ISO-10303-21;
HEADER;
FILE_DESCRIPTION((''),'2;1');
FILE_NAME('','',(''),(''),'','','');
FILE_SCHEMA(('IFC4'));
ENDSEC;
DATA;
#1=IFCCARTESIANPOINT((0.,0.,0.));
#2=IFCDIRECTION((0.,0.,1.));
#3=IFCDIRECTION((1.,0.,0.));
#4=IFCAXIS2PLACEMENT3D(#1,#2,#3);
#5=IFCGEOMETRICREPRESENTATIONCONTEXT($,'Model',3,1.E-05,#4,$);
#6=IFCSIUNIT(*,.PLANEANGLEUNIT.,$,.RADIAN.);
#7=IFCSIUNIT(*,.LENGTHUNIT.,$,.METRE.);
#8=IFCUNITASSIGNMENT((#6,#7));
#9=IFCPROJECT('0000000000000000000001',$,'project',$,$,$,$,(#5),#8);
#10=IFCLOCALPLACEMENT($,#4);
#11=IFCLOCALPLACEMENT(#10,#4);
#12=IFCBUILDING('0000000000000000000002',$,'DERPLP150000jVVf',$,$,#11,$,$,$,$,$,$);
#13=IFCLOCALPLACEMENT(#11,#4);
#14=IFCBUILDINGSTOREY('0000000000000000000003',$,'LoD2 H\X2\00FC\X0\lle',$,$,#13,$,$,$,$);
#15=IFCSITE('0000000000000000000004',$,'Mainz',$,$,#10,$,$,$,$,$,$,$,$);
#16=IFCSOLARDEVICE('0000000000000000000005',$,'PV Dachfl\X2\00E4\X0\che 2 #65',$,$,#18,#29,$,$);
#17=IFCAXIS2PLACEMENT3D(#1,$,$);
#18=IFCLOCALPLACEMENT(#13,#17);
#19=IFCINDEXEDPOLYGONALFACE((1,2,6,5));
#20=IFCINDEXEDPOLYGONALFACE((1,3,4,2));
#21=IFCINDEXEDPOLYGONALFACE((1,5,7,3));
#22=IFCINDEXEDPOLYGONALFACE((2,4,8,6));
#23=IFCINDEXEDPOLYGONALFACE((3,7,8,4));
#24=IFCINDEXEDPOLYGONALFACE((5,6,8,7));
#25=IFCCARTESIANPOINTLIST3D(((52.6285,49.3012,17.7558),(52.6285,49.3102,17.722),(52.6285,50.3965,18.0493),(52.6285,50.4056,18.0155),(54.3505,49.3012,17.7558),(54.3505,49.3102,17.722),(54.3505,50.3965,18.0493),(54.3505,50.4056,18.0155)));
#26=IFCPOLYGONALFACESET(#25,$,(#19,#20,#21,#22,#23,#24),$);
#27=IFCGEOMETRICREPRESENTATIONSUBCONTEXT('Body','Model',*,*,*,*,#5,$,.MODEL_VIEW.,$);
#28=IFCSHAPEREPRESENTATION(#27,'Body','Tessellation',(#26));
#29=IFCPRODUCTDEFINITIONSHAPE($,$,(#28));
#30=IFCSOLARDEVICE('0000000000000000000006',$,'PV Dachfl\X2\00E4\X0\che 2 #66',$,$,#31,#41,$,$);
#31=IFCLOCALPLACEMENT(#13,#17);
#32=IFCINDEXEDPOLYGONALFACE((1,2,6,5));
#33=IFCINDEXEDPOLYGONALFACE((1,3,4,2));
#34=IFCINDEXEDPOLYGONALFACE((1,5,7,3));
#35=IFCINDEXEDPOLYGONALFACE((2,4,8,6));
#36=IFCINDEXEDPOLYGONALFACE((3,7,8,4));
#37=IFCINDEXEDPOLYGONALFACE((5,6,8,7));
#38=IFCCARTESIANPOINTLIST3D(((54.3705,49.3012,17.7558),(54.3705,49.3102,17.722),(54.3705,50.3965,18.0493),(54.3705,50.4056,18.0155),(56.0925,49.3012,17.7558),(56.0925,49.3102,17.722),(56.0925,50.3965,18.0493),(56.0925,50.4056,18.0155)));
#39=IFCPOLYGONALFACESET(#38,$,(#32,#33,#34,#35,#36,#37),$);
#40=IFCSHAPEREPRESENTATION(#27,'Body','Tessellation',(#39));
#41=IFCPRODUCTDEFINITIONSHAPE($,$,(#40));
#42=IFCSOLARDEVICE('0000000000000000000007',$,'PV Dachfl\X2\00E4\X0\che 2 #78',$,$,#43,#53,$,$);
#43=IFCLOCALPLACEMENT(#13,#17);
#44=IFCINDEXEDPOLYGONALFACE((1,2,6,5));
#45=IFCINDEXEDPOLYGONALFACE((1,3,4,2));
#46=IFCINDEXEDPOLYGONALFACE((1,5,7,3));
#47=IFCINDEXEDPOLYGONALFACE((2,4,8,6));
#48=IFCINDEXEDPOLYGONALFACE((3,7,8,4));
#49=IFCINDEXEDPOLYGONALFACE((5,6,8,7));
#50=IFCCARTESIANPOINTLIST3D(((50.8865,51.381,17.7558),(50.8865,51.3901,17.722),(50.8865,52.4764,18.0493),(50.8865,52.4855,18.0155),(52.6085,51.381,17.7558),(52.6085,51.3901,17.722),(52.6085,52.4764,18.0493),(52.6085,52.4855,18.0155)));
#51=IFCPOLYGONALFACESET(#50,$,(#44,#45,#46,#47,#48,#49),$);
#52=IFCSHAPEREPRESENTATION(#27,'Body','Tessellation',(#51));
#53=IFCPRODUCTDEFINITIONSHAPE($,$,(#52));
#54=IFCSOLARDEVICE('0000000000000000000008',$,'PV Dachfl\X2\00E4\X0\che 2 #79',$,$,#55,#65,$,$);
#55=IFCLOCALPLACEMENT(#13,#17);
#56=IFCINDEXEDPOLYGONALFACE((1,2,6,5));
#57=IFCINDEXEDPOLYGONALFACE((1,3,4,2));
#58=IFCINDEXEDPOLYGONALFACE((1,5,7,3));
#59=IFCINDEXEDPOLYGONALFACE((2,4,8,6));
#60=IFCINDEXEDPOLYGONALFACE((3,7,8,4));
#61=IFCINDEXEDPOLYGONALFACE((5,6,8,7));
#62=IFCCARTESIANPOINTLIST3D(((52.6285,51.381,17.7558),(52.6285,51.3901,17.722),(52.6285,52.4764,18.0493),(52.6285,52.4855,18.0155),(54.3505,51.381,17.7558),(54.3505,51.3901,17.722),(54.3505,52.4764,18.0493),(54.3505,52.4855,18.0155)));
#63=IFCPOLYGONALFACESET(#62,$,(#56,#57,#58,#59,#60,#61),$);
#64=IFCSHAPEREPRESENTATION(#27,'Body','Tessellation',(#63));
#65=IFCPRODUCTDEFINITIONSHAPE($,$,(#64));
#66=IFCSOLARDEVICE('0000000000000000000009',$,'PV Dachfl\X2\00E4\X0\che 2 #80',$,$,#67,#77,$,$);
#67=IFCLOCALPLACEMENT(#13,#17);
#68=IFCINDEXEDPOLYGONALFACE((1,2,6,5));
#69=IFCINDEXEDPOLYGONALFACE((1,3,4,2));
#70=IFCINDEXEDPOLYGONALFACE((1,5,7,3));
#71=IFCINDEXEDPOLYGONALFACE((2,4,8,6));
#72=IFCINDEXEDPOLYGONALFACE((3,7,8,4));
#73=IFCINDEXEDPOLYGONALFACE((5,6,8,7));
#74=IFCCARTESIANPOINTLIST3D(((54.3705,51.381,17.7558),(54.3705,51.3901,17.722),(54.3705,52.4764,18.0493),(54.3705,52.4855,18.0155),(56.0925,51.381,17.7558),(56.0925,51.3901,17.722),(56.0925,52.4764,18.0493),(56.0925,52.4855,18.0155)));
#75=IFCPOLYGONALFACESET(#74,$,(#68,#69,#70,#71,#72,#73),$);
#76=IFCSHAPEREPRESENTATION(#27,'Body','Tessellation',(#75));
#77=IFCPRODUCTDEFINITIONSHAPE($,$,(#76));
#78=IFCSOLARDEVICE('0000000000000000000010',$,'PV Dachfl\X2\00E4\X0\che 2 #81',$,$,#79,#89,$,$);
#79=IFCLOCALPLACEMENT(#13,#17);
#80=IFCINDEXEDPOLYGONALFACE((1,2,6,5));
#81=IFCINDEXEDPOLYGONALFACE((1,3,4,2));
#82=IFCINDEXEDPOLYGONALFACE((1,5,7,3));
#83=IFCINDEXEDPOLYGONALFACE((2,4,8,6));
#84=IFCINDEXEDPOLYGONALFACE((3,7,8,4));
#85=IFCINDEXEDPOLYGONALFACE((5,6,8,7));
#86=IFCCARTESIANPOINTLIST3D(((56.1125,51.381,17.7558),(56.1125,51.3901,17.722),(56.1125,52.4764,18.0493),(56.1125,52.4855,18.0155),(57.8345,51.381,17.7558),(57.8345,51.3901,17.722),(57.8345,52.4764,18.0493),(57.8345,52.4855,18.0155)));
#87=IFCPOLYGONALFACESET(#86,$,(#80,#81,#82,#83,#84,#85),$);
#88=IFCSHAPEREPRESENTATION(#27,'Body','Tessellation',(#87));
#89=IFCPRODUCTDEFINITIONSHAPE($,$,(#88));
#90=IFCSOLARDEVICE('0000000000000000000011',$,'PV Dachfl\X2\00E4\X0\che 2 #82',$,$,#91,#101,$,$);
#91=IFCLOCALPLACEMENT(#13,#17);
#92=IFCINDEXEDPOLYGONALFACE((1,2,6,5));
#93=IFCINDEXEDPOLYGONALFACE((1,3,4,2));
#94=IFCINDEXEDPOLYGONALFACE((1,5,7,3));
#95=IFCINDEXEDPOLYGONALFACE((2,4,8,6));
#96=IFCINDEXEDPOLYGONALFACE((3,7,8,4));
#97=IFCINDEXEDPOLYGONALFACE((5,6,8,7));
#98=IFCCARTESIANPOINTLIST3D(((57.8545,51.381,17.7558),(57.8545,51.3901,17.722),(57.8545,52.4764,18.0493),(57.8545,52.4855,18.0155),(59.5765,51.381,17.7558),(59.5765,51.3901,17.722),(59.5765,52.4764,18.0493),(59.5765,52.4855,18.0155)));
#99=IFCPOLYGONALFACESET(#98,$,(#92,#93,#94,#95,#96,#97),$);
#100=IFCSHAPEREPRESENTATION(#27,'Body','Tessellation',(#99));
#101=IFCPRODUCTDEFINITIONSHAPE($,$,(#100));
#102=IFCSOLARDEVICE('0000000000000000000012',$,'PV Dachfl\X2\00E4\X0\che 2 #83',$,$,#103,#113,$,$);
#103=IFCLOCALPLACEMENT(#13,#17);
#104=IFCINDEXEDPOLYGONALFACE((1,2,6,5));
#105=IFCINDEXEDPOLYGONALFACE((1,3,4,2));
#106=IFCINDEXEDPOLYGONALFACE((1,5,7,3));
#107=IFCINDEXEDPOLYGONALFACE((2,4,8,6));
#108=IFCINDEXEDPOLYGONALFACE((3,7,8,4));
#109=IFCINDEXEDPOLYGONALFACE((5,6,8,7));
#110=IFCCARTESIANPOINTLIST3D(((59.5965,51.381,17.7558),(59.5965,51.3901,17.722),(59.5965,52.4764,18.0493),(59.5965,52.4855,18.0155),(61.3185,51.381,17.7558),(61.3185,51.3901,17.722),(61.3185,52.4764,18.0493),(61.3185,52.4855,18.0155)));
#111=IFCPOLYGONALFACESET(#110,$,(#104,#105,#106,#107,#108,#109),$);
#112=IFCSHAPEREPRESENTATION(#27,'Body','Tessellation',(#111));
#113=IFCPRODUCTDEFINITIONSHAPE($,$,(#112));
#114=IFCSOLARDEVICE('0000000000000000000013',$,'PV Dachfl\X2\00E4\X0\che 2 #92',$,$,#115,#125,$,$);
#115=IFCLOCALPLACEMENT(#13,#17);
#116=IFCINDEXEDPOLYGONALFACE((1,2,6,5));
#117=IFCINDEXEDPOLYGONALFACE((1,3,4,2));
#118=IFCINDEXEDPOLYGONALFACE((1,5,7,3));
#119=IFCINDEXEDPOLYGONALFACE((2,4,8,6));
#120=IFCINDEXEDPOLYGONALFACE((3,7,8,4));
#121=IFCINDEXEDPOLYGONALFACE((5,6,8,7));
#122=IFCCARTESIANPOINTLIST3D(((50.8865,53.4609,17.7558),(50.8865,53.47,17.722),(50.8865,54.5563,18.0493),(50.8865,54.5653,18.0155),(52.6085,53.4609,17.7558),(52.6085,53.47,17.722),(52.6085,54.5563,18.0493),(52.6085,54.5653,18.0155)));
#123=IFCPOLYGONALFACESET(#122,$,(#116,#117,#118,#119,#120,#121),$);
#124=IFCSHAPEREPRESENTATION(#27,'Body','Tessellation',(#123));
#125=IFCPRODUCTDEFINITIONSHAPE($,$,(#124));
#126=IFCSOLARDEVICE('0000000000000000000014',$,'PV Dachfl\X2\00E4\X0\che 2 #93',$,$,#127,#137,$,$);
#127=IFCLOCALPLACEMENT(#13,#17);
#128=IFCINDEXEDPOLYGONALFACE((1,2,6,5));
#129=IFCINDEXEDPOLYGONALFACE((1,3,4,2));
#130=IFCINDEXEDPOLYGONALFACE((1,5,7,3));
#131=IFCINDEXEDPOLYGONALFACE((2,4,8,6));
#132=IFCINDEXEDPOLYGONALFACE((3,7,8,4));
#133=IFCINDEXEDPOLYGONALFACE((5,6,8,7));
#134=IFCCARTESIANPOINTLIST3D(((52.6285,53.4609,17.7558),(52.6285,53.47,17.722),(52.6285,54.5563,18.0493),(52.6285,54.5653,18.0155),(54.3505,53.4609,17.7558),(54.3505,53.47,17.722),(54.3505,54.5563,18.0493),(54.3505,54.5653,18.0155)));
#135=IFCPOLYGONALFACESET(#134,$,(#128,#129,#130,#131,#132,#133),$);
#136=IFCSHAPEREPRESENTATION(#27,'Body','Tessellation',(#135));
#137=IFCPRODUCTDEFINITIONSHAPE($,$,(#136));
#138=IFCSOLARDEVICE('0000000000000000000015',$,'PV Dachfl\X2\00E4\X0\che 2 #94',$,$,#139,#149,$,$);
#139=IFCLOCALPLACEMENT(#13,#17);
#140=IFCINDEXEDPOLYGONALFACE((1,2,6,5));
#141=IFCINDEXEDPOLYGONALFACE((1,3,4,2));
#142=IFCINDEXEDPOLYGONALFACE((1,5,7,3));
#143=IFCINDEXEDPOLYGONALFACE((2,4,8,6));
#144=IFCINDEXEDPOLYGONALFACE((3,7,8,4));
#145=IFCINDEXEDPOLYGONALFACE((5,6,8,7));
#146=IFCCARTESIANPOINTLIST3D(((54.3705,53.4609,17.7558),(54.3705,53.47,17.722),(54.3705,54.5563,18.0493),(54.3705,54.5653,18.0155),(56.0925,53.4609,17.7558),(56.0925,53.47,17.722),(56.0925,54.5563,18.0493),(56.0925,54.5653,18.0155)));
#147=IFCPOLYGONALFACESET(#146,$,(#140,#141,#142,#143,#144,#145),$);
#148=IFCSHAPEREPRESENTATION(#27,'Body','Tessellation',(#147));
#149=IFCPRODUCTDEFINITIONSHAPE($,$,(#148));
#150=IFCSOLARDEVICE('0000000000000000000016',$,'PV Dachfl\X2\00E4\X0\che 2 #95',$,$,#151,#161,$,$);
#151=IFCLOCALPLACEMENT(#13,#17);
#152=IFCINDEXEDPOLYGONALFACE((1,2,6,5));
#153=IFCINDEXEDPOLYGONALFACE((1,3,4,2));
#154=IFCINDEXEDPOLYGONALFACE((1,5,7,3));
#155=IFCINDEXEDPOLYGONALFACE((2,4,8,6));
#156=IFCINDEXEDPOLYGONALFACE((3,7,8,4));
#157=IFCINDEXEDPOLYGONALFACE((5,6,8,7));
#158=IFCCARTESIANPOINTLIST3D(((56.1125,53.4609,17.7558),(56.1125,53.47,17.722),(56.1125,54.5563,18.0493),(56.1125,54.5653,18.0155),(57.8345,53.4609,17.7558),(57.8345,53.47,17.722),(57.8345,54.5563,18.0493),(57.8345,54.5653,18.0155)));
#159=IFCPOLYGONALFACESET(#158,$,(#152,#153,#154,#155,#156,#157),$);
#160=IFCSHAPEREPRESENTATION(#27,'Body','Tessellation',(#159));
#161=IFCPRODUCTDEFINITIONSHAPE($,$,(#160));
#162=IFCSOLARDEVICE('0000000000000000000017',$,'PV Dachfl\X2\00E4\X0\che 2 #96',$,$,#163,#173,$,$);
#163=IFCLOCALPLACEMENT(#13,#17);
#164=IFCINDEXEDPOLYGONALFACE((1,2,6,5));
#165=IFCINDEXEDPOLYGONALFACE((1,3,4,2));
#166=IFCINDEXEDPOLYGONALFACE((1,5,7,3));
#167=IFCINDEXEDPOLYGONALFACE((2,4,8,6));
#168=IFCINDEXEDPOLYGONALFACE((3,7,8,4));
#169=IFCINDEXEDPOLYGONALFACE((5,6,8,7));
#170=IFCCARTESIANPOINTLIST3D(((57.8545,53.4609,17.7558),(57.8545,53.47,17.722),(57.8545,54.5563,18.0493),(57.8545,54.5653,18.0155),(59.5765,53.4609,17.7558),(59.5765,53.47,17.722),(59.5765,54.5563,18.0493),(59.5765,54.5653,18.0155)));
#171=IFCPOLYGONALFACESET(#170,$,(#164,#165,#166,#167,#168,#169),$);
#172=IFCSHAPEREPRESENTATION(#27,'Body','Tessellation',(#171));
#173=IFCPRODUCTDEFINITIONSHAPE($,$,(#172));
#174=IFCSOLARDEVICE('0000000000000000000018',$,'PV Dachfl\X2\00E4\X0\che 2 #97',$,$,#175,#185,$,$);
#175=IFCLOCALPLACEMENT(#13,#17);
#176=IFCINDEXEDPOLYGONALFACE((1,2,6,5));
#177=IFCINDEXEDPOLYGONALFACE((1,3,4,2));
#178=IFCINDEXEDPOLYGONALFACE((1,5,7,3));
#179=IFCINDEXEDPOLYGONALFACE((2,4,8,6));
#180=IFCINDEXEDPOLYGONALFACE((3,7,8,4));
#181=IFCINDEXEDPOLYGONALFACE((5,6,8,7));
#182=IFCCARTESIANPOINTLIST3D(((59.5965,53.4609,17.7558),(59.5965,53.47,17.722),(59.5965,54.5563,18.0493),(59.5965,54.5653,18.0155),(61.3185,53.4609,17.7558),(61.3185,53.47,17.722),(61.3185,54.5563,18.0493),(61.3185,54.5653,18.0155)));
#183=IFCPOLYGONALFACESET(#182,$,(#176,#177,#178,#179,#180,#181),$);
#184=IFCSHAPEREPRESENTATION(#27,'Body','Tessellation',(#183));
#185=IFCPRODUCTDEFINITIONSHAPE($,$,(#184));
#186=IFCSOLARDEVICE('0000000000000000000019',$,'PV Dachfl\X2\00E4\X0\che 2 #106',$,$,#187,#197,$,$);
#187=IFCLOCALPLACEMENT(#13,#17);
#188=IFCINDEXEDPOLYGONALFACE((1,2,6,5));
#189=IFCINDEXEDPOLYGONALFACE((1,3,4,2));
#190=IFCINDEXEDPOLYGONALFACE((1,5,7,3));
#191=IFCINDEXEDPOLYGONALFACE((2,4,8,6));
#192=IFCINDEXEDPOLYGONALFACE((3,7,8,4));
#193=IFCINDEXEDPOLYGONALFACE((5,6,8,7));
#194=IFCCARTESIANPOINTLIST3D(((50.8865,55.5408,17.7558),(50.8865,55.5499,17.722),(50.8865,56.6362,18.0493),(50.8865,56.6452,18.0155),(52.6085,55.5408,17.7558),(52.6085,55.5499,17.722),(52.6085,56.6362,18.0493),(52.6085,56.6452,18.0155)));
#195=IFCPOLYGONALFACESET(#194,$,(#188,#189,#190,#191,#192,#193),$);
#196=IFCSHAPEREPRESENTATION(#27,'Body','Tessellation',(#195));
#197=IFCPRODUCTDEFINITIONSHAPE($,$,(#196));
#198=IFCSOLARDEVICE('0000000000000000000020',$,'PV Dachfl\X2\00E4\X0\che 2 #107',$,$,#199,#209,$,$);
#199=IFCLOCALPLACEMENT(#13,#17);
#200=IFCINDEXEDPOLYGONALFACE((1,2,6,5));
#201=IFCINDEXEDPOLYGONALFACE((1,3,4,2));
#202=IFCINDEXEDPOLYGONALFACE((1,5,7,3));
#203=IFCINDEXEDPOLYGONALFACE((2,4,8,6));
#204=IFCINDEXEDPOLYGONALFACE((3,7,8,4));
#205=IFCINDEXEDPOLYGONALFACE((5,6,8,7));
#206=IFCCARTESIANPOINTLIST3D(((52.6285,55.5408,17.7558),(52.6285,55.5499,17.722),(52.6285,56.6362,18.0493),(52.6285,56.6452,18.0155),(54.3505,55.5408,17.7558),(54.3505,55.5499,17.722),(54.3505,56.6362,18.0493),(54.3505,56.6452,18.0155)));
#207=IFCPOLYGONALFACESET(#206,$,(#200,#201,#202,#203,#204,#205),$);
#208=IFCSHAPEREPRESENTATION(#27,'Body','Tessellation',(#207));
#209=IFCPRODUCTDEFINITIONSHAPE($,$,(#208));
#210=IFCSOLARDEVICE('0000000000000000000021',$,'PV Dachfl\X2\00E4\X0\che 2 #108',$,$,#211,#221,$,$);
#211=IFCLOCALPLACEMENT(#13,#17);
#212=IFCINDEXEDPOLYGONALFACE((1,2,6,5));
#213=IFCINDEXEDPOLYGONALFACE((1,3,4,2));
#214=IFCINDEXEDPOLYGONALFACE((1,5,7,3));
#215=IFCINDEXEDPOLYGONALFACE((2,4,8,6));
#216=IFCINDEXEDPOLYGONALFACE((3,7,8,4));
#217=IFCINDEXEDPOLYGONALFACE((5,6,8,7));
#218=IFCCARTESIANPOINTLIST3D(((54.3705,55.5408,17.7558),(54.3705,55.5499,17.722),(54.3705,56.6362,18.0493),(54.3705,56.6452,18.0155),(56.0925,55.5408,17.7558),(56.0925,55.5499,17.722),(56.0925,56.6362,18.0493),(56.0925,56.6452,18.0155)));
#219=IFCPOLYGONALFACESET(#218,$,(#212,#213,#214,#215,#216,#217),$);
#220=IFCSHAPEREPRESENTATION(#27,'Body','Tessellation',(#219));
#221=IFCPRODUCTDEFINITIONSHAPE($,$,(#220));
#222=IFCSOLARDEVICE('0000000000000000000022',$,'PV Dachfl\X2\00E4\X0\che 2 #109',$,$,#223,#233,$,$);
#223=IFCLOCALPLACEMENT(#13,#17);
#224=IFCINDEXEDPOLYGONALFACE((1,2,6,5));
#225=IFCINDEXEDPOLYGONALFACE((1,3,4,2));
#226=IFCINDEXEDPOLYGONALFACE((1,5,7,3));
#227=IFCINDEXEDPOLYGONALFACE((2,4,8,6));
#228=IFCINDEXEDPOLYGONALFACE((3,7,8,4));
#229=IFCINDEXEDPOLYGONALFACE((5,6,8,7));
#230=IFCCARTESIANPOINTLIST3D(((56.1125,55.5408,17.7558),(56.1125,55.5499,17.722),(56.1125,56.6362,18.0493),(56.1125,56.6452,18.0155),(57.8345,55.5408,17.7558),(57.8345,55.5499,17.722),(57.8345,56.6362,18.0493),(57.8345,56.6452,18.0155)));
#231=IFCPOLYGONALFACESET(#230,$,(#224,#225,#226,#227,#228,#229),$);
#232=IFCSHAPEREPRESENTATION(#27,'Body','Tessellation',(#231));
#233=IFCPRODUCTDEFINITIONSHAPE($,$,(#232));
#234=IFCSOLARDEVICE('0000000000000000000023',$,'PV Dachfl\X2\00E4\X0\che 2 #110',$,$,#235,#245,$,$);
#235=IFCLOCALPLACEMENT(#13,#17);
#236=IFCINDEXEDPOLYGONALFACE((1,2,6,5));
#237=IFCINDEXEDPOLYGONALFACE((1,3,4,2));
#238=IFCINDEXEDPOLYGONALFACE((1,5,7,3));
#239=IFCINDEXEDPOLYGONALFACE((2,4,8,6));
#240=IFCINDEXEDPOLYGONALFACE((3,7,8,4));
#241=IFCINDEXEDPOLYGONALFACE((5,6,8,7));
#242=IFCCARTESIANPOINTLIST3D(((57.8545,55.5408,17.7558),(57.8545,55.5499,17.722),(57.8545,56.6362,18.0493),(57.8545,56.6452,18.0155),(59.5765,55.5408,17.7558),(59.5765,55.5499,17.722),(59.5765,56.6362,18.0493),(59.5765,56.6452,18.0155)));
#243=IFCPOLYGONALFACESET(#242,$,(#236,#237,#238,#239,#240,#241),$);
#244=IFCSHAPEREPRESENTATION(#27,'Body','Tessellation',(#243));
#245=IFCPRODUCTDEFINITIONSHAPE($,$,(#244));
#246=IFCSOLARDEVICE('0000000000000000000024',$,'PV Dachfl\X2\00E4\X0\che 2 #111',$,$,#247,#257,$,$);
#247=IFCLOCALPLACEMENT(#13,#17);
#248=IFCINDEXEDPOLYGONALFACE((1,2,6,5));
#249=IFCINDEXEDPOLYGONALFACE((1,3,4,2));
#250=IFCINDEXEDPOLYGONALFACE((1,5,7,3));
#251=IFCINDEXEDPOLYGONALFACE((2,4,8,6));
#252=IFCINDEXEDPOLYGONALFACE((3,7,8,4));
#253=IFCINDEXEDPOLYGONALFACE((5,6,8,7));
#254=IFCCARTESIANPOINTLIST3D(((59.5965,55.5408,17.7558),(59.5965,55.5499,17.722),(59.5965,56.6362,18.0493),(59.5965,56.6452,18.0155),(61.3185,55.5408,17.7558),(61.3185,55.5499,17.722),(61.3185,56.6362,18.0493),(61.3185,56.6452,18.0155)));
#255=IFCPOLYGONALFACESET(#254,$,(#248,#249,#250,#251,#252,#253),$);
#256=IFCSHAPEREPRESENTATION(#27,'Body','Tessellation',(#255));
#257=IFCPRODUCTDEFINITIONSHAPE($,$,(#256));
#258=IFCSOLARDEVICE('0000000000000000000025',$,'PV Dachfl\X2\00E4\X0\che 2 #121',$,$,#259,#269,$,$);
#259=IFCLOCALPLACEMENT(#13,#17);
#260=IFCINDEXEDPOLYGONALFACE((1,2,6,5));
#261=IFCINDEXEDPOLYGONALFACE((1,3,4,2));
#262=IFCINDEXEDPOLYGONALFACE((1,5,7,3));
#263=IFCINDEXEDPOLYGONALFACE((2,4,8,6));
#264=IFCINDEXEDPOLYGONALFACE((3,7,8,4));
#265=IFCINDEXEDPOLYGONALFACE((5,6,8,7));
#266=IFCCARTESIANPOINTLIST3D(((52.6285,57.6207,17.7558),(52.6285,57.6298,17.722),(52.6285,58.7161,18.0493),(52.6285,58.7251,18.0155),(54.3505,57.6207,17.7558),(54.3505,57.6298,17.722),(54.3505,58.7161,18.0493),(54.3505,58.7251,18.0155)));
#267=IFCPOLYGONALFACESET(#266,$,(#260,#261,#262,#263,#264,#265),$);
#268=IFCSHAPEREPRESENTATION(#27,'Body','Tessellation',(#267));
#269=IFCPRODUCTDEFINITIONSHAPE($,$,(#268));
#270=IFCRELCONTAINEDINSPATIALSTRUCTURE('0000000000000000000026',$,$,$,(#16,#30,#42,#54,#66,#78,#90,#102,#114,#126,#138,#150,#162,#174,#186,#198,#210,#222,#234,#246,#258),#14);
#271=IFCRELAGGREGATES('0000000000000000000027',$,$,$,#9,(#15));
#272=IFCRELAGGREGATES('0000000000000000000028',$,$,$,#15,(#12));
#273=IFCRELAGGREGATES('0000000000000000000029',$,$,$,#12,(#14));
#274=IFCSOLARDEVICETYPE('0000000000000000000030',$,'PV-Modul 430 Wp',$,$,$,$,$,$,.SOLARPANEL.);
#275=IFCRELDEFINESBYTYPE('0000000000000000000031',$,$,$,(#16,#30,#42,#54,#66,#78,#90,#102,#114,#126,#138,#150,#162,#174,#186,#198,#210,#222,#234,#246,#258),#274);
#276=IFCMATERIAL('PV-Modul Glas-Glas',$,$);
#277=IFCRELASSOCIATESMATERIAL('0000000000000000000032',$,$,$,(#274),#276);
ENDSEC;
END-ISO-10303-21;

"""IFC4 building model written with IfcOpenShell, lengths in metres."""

from ifc_helpers import new_model, si_unit, frame, frame_2d, origin, origin_with_axes, place, context, subcontext, project, spatial, rectangle, extrude, source, transform, mapped, material, type_object, type_shapes, element, save


model = new_model("IFC4")

# Units and contexts
model_context = context("Model", 3, precision=1e-05, world=origin_with_axes())
body_context = subcontext(model_context, "Body", "Model", "MODEL_VIEW")
ifc_project = project(units=[si_unit("PLANEANGLEUNIT", "RADIAN"), si_unit("LENGTHUNIT", "METRE")], contexts=[model_context])

# Site, building, storey
site_placement = place(None, origin_with_axes())
site = spatial("IfcSite", under=ifc_project, at=site_placement, Name="Mainz")
building_placement = place(site_placement, origin_with_axes())
building = spatial("IfcBuilding", under=site, at=building_placement, Name="DERPLP150000jVVf")
storey_placement = place(building_placement, origin_with_axes())
storey = spatial("IfcBuildingStorey", under=building, at=storey_placement, Name="LoD2 Hülle")

# Solar devices
ifc_material = material(Name="PV-Modul Glas-Glas")
solar_device_type = type_object("IfcSolarDeviceType", Name="PV-Modul 430 Wp", PredefinedType="SOLARPANEL", material=ifc_material)
shared_shape = source(origin_with_axes(), body_context, "Body", "SweptSolid", [
    extrude(rectangle(XDim=1.722, YDim=1.134, at=frame_2d((0.861, 0.567))), origin(), (0.0, 0.0, 1.0), 0.035),
])
type_shapes(solar_device_type, [shared_shape])
for number, where, z_axis, x_axis, name in (
    (1, (52.6285, 49.3102, 17.722), (0.0, -0.258819, 0.965926), (1.0, 0.0, 0.0), "PV Dachfläche 2 #65"),
    (2, (54.3705, 49.3102, 17.722), (0.0, -0.258819, 0.965926), (1.0, 0.0, 0.0), "PV Dachfläche 2 #66"),
    (3, (50.8865, 51.3901, 17.722), (0.0, -0.258819, 0.965926), (1.0, 0.0, 0.0), "PV Dachfläche 2 #78"),
    (4, (52.6285, 51.3901, 17.722), (0.0, -0.258819, 0.965926), (1.0, 0.0, 0.0), "PV Dachfläche 2 #79"),
    (5, (54.3705, 51.3901, 17.722), (0.0, -0.258819, 0.965926), (1.0, 0.0, 0.0), "PV Dachfläche 2 #80"),
    (6, (56.1125, 51.3901, 17.722), (0.0, -0.258819, 0.965926), (1.0, 0.0, 0.0), "PV Dachfläche 2 #81"),
    (7, (57.8545, 51.3901, 17.722), (0.0, -0.258819, 0.965926), (1.0, 0.0, 0.0), "PV Dachfläche 2 #82"),
    (8, (59.5965, 51.3901, 17.722), (0.0, -0.258819, 0.965926), (1.0, 0.0, 0.0), "PV Dachfläche 2 #83"),
    (9, (50.8865, 53.47, 17.722), (0.0, -0.258819, 0.965926), (1.0, 0.0, 0.0), "PV Dachfläche 2 #92"),
    (10, (52.6285, 53.47, 17.722), (0.0, -0.258819, 0.965926), (1.0, 0.0, 0.0), "PV Dachfläche 2 #93"),
    (11, (54.3705, 53.47, 17.722), (0.0, -0.258819, 0.965926), (1.0, 0.0, 0.0), "PV Dachfläche 2 #94"),
    (12, (56.1125, 53.47, 17.722), (0.0, -0.258819, 0.965926), (1.0, 0.0, 0.0), "PV Dachfläche 2 #95"),
    (13, (57.8545, 53.47, 17.722), (0.0, -0.258819, 0.965926), (1.0, 0.0, 0.0), "PV Dachfläche 2 #96"),
    (14, (59.5965, 53.47, 17.722), (0.0, -0.258819, 0.965926), (1.0, 0.0, 0.0), "PV Dachfläche 2 #97"),
    (15, (50.8865, 55.5499, 17.722), (0.0, -0.258819, 0.965926), (1.0, 0.0, 0.0), "PV Dachfläche 2 #106"),
    (16, (52.6285, 55.5499, 17.722), (0.0, -0.258819, 0.965926), (1.0, 0.0, 0.0), "PV Dachfläche 2 #107"),
    (17, (54.3705, 55.5499, 17.722), (0.0, -0.258819, 0.965926), (1.0, 0.0, 0.0), "PV Dachfläche 2 #108"),
    (18, (56.1125, 55.5499, 17.722), (0.0, -0.258819, 0.965926), (1.0, 0.0, 0.0), "PV Dachfläche 2 #109"),
    (19, (57.8545, 55.5499, 17.722), (0.0, -0.258819, 0.965926), (1.0, 0.0, 0.0), "PV Dachfläche 2 #110"),
    (20, (59.5965, 55.5499, 17.722), (0.0, -0.258819, 0.965926), (1.0, 0.0, 0.0), "PV Dachfläche 2 #111"),
    (21, (52.6285, 57.6298, 17.722), (0.0, -0.258819, 0.965926), (1.0, 0.0, 0.0), "PV Dachfläche 2 #121"),
):
    element("IfcSolarDevice", number, at=place(storey_placement, frame(where, z_axis=z_axis, x_axis=x_axis)), inside=storey, type_object=solar_device_type, Name=name, context=body_context, shape_type="MappedRepresentation", body=[
        mapped(shared_shape, transform((0.0, 0.0, 0.0), x_axis=(1.0, 0.0, 0.0), y_axis=(0.0, 1.0, 0.0), z_axis=(0.0, 0.0, 1.0), scale=1.0)),
    ])

save(model, "model.ifc")
